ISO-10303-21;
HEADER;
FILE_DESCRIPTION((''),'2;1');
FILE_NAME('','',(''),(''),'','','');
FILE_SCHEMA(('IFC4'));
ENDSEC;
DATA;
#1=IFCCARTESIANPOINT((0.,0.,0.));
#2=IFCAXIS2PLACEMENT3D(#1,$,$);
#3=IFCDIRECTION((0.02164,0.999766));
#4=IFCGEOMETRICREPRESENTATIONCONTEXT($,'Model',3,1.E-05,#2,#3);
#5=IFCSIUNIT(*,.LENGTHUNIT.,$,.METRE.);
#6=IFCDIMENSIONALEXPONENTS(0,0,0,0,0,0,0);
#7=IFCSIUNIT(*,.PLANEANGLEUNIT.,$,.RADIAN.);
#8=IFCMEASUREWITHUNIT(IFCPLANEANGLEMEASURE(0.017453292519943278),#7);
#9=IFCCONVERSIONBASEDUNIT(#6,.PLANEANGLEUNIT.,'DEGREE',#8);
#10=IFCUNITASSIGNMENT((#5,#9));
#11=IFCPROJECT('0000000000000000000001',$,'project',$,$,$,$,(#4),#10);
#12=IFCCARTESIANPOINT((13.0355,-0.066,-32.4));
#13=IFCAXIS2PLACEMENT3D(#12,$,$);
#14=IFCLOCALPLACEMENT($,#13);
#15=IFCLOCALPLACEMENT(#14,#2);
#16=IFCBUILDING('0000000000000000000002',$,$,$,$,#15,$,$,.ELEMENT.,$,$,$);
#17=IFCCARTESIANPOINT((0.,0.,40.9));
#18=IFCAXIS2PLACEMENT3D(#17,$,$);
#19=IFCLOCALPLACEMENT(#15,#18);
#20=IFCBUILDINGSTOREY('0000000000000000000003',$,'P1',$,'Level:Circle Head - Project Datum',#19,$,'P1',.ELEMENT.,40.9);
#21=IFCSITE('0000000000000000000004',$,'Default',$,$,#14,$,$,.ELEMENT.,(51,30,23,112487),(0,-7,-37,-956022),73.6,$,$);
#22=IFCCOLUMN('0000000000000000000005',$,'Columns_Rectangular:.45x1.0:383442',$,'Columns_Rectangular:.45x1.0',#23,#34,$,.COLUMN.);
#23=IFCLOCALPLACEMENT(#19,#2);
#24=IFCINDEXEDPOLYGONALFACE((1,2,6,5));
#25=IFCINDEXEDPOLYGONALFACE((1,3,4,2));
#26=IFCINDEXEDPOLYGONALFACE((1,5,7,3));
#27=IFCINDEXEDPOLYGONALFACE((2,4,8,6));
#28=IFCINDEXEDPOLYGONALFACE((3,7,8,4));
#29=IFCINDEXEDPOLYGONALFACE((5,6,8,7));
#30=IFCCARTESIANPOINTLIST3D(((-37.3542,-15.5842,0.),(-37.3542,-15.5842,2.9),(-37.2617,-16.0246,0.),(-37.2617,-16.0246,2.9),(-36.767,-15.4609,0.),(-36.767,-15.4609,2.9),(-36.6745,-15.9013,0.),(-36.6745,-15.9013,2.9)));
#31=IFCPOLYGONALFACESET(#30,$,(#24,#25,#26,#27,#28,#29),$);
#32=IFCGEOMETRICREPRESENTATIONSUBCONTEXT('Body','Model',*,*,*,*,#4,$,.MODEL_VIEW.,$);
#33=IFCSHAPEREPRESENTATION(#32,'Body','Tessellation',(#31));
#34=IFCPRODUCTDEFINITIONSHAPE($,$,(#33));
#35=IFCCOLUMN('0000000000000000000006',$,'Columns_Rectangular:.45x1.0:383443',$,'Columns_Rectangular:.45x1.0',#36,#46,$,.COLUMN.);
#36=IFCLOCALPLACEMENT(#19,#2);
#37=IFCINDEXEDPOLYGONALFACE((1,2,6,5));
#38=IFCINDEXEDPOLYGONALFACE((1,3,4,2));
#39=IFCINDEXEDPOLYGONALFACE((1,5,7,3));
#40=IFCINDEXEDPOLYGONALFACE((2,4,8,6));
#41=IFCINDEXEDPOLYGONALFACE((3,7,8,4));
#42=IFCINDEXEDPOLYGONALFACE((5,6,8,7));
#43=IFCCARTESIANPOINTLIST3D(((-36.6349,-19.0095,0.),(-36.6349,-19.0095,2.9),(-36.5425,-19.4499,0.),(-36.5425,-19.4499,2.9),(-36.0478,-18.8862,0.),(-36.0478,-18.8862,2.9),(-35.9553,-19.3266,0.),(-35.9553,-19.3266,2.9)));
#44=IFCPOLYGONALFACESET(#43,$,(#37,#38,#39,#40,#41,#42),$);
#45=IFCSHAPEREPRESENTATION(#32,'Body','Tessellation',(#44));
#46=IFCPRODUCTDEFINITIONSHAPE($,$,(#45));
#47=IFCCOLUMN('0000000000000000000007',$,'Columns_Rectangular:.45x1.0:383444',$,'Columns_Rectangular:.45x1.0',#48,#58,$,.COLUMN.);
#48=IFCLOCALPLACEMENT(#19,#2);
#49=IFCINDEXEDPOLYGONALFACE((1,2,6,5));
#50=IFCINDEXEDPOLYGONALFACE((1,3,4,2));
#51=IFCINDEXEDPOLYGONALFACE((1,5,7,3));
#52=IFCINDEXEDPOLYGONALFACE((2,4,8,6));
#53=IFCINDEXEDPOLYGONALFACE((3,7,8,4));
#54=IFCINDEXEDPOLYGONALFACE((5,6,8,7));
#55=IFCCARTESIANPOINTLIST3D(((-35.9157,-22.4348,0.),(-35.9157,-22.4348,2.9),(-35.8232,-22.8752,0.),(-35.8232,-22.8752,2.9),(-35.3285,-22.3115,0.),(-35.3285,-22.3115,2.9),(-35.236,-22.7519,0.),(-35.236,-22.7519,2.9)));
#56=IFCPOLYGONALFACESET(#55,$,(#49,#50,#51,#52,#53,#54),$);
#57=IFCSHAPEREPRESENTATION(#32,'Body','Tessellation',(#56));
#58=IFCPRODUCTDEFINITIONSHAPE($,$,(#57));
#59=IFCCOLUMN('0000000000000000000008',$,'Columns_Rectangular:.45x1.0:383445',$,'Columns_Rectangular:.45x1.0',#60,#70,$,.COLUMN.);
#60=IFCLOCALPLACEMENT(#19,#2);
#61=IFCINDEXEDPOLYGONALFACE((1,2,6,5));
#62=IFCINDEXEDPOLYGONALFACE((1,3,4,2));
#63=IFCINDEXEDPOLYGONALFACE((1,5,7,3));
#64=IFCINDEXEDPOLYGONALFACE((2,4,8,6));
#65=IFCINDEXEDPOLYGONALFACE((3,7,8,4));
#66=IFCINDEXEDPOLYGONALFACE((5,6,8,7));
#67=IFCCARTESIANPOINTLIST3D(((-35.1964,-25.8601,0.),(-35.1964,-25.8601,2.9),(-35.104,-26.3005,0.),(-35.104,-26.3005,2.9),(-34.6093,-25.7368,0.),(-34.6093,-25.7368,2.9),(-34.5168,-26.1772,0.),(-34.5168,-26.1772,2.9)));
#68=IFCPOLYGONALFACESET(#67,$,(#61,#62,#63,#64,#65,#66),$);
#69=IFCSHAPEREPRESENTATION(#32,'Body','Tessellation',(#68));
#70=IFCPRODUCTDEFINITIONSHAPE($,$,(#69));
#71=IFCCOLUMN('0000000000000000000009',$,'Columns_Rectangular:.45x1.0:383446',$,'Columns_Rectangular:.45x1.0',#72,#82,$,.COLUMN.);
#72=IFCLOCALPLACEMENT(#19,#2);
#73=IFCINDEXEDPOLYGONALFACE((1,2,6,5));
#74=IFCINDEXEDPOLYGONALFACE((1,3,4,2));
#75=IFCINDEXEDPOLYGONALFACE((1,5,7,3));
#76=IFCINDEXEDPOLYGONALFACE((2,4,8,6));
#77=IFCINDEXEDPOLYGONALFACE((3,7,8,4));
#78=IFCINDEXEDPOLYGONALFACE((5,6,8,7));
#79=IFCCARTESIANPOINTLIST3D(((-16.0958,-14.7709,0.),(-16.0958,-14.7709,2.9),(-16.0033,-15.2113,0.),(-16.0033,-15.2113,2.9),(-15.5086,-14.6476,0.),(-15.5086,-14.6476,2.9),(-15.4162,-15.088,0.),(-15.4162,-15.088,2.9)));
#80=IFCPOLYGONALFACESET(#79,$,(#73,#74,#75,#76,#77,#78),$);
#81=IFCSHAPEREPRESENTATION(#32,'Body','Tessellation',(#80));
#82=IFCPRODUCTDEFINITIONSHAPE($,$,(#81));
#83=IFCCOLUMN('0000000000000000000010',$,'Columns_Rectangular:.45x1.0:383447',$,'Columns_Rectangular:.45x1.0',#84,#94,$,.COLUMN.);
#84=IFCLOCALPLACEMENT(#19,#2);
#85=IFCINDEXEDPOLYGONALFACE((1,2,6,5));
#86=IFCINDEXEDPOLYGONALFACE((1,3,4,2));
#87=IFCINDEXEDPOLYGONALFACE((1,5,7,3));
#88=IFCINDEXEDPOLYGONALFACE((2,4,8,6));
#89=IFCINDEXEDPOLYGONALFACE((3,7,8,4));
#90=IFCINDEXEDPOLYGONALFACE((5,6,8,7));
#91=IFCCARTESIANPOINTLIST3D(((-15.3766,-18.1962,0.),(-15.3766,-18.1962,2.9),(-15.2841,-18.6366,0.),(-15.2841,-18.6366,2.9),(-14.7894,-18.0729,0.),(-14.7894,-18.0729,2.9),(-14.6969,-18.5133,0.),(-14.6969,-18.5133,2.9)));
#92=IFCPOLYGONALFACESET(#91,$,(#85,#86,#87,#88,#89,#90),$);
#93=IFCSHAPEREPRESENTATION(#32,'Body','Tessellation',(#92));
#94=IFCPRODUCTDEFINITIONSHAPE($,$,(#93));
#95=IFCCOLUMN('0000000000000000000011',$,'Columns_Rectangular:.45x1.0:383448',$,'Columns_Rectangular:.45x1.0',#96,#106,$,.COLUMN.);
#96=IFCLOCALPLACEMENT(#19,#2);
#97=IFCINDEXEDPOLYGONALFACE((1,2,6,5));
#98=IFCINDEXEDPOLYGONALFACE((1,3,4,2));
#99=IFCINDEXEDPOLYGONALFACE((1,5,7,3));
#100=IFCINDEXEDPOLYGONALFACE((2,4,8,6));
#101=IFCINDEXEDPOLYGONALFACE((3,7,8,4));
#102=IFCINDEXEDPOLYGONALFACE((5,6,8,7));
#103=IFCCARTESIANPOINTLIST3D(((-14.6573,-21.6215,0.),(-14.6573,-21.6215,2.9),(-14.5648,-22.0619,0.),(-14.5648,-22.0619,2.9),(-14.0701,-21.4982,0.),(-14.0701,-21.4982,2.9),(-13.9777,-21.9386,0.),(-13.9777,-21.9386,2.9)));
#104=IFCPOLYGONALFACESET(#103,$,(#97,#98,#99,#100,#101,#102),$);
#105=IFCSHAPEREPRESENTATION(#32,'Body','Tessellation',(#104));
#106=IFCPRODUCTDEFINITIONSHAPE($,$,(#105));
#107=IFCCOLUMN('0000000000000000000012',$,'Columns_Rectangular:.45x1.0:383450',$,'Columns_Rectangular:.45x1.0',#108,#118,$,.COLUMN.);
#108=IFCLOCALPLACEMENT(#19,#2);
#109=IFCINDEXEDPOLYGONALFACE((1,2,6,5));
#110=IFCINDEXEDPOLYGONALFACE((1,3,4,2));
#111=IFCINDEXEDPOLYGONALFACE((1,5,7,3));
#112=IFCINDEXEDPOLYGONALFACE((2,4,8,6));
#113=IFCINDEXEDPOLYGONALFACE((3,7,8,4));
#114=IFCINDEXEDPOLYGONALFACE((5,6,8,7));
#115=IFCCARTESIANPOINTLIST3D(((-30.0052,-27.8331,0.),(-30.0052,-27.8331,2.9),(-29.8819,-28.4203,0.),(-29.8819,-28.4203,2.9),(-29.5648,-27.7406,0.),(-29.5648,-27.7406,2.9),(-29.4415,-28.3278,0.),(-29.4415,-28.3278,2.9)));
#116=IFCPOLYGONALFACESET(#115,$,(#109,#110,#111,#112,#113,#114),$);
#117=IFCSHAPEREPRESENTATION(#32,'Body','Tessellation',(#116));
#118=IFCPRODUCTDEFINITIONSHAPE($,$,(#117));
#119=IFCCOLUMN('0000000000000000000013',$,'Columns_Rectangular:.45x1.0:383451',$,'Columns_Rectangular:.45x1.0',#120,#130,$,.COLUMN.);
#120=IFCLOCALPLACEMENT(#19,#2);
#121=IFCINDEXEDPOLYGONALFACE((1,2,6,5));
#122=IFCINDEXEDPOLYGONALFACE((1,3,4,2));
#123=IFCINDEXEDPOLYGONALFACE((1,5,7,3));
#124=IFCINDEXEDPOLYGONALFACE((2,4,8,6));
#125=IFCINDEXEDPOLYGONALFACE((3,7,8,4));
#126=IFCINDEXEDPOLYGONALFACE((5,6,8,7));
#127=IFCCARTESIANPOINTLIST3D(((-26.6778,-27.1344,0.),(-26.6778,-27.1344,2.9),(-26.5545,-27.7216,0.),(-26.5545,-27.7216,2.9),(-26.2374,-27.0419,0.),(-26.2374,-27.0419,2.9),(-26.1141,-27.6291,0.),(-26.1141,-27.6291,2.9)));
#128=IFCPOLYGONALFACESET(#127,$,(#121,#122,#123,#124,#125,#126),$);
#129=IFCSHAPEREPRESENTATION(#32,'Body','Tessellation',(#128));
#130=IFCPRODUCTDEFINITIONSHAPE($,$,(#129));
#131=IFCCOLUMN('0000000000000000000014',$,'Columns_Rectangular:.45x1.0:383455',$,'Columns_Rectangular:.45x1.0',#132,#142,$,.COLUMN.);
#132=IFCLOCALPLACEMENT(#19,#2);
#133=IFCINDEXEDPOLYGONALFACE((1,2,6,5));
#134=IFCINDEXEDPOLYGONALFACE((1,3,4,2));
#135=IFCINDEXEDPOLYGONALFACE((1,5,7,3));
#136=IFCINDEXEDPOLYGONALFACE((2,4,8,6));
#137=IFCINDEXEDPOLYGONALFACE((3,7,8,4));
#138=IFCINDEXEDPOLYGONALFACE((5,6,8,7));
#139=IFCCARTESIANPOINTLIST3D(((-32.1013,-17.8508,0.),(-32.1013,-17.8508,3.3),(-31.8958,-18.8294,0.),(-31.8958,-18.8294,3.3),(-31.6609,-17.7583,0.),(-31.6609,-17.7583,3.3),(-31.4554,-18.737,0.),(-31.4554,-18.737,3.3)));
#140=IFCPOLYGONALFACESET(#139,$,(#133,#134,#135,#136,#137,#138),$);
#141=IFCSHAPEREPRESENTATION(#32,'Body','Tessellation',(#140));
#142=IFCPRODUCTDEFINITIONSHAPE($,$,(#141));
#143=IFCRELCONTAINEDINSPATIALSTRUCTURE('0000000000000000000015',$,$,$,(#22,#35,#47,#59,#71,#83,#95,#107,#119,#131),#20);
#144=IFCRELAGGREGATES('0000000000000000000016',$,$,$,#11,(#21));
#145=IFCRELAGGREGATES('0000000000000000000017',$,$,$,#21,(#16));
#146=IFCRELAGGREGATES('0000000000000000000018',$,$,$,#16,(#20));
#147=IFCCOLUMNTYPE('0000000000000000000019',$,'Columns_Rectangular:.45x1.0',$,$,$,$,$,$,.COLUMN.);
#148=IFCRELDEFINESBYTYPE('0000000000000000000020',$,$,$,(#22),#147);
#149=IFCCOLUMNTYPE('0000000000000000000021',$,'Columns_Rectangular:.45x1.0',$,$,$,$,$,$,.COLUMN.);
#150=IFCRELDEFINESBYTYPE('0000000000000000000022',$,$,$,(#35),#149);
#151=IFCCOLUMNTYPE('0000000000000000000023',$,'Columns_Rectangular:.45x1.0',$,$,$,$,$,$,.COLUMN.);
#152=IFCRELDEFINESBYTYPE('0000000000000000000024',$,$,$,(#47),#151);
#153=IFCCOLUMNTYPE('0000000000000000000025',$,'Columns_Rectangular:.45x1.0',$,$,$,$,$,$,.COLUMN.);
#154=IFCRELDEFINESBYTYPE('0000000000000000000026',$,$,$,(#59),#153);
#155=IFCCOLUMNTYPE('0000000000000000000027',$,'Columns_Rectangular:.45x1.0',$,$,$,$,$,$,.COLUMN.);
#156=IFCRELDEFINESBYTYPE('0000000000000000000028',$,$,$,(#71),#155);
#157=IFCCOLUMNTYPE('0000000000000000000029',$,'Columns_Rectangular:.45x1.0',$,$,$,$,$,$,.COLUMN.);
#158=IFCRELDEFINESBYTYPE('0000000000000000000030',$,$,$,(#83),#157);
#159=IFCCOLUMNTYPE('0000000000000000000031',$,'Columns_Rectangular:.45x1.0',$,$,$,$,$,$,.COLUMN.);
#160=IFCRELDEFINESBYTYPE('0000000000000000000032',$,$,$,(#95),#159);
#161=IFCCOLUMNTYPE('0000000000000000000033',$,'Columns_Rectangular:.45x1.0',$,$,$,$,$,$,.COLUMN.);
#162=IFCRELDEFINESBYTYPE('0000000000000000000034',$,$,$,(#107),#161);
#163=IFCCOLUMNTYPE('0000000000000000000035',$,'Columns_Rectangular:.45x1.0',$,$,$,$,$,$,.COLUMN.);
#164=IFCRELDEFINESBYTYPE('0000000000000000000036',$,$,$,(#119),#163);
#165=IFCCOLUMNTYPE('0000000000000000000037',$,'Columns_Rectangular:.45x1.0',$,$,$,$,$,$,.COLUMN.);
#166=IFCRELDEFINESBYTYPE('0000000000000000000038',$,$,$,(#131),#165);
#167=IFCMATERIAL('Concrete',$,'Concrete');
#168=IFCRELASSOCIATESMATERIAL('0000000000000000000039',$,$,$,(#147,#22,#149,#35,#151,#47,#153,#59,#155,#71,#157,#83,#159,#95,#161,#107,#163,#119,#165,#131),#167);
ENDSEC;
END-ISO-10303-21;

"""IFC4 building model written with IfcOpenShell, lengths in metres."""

from ifc_helpers import new_model, entity, si_unit, converted_unit, direction, frame, origin, place, context, subcontext, project, spatial, indexed_curve, outline, extrude, source, transform, mapped, material, type_object, type_shapes, element, save


model = new_model("IFC4")

# Units and contexts
model_context = context("Model", 3, precision=1e-05, world=origin(), true_north=direction((0.02164, 0.999766)))
body_context = subcontext(model_context, "Body", "Model", "MODEL_VIEW")
ifc_project = project(units=[si_unit("LENGTHUNIT", "METRE"), converted_unit("PLANEANGLEUNIT", "DEGREE", entity("IfcPlaneAngleMeasure", 0.017453292519943278), si_unit("PLANEANGLEUNIT", "RADIAN"), dimensions=[0, 0, 0, 0, 0, 0, 0])], contexts=[model_context])

# Site, building, storey
site_placement = place(None, frame((13.0355, -0.066, -32.4)))
site = spatial("IfcSite", under=ifc_project, at=site_placement, Name="Default", CompositionType="ELEMENT", RefLatitude=(51, 30, 23, 112487), RefLongitude=(0, -7, -37, -956022), RefElevation=73.6)
building_placement = place(site_placement, origin())
building = spatial("IfcBuilding", under=site, at=building_placement, CompositionType="ELEMENT")
storey_placement = place(building_placement, frame((0.0, 0.0, 40.9)))
storey = spatial("IfcBuildingStorey", under=building, at=storey_placement, Name="P1", ObjectType="Level:Circle Head - Project Datum", LongName="P1", CompositionType="ELEMENT", Elevation=40.9)

# Columns
ifc_material = material(Name="Concrete", Category="Concrete")
column_type_1 = type_object("IfcColumnType", Name="Columns_Rectangular:.45x1.0", PredefinedType="COLUMN", material=ifc_material)
shared_shape_1 = source(origin(), body_context, "Body", "SweptSolid", [
    extrude(outline(indexed_curve([(-0.3, -0.225), (0.3, -0.225), (0.3, 0.225), (-0.3, 0.225), (-0.3, -0.225)], self_intersect=False)), frame((-37.0144, -15.7427, 40.9), z_axis=(0.0, 0.0, 1.0), x_axis=(0.978657, 0.2055, 0.0)), (0.0, 0.0, 1.0), 2.9),
])
type_shapes(column_type_1, [shared_shape_1])
column_1_placement = place(storey_placement, frame((0.0, 0.0, -40.9)))
element("IfcColumn", 1, at=column_1_placement, inside=storey, type_object=column_type_1, material=ifc_material, Name="Columns_Rectangular:.45x1.0:383442", ObjectType="Columns_Rectangular:.45x1.0", PredefinedType="COLUMN", context=body_context, shape_type="MappedRepresentation", body=[
    mapped(shared_shape_1, transform((0.0, 0.0, 0.0), scale=1.0)),
])
column_type_2 = type_object("IfcColumnType", Name="Columns_Rectangular:.45x1.0", PredefinedType="COLUMN", material=ifc_material)
shared_shape_2 = source(origin(), body_context, "Body", "SweptSolid", [
    extrude(outline(indexed_curve([(-0.3, -0.225), (0.3, -0.225), (0.3, 0.225), (-0.3, 0.225), (-0.3, -0.225)], self_intersect=False)), frame((-36.2951, -19.168, 40.9), z_axis=(0.0, 0.0, 1.0), x_axis=(0.978657, 0.2055, 0.0)), (0.0, 0.0, 1.0), 2.9),
])
type_shapes(column_type_2, [shared_shape_2])
column_2_placement = place(storey_placement, frame((0.0, 0.0, -40.9)))
element("IfcColumn", 2, at=column_2_placement, inside=storey, type_object=column_type_2, material=ifc_material, Name="Columns_Rectangular:.45x1.0:383443", ObjectType="Columns_Rectangular:.45x1.0", PredefinedType="COLUMN", context=body_context, shape_type="MappedRepresentation", body=[
    mapped(shared_shape_2, transform((0.0, 0.0, 0.0), scale=1.0)),
])
column_type_3 = type_object("IfcColumnType", Name="Columns_Rectangular:.45x1.0", PredefinedType="COLUMN", material=ifc_material)
shared_shape_3 = source(origin(), body_context, "Body", "SweptSolid", [
    extrude(outline(indexed_curve([(-0.3, -0.225), (0.3, -0.225), (0.3, 0.225), (-0.3, 0.225), (-0.3, -0.225)], self_intersect=False)), frame((-35.5759, -22.5933, 40.9), z_axis=(0.0, 0.0, 1.0), x_axis=(0.978657, 0.2055, 0.0)), (0.0, 0.0, 1.0), 2.9),
])
type_shapes(column_type_3, [shared_shape_3])
column_3_placement = place(storey_placement, frame((0.0, 0.0, -40.9)))
element("IfcColumn", 3, at=column_3_placement, inside=storey, type_object=column_type_3, material=ifc_material, Name="Columns_Rectangular:.45x1.0:383444", ObjectType="Columns_Rectangular:.45x1.0", PredefinedType="COLUMN", context=body_context, shape_type="MappedRepresentation", body=[
    mapped(shared_shape_3, transform((0.0, 0.0, 0.0), scale=1.0)),
])
column_type_4 = type_object("IfcColumnType", Name="Columns_Rectangular:.45x1.0", PredefinedType="COLUMN", material=ifc_material)
shared_shape_4 = source(origin(), body_context, "Body", "SweptSolid", [
    extrude(outline(indexed_curve([(-0.3, -0.225), (0.3, -0.225), (0.3, 0.225), (-0.3, 0.225), (-0.3, -0.225)], self_intersect=False)), frame((-34.8566, -26.0186, 40.9), z_axis=(0.0, 0.0, 1.0), x_axis=(0.978657, 0.2055, 0.0)), (0.0, 0.0, 1.0), 2.9),
])
type_shapes(column_type_4, [shared_shape_4])
column_4_placement = place(storey_placement, frame((0.0, 0.0, -40.9)))
element("IfcColumn", 4, at=column_4_placement, inside=storey, type_object=column_type_4, material=ifc_material, Name="Columns_Rectangular:.45x1.0:383445", ObjectType="Columns_Rectangular:.45x1.0", PredefinedType="COLUMN", context=body_context, shape_type="MappedRepresentation", body=[
    mapped(shared_shape_4, transform((0.0, 0.0, 0.0), scale=1.0)),
])
column_type_5 = type_object("IfcColumnType", Name="Columns_Rectangular:.45x1.0", PredefinedType="COLUMN", material=ifc_material)
shared_shape_5 = source(origin(), body_context, "Body", "SweptSolid", [
    extrude(outline(indexed_curve([(-0.3, -0.225), (0.3, -0.225), (0.3, 0.225), (-0.3, 0.225), (-0.3, -0.225)], self_intersect=False)), frame((-15.756, -14.9295, 40.9), z_axis=(0.0, 0.0, 1.0), x_axis=(0.978657, 0.2055, 0.0)), (0.0, 0.0, 1.0), 2.9),
])
type_shapes(column_type_5, [shared_shape_5])
column_5_placement = place(storey_placement, frame((0.0, 0.0, -40.9)))
element("IfcColumn", 5, at=column_5_placement, inside=storey, type_object=column_type_5, material=ifc_material, Name="Columns_Rectangular:.45x1.0:383446", ObjectType="Columns_Rectangular:.45x1.0", PredefinedType="COLUMN", context=body_context, shape_type="MappedRepresentation", body=[
    mapped(shared_shape_5, transform((0.0, 0.0, 0.0), scale=1.0)),
])
column_type_6 = type_object("IfcColumnType", Name="Columns_Rectangular:.45x1.0", PredefinedType="COLUMN", material=ifc_material)
shared_shape_6 = source(origin(), body_context, "Body", "SweptSolid", [
    extrude(outline(indexed_curve([(-0.3, -0.225), (0.3, -0.225), (0.3, 0.225), (-0.3, 0.225), (-0.3, -0.225)], self_intersect=False)), frame((-15.0367, -18.3548, 40.9), z_axis=(0.0, 0.0, 1.0), x_axis=(0.978657, 0.2055, 0.0)), (0.0, 0.0, 1.0), 2.9),
])
type_shapes(column_type_6, [shared_shape_6])
column_6_placement = place(storey_placement, frame((0.0, 0.0, -40.9)))
element("IfcColumn", 6, at=column_6_placement, inside=storey, type_object=column_type_6, material=ifc_material, Name="Columns_Rectangular:.45x1.0:383447", ObjectType="Columns_Rectangular:.45x1.0", PredefinedType="COLUMN", context=body_context, shape_type="MappedRepresentation", body=[
    mapped(shared_shape_6, transform((0.0, 0.0, 0.0), scale=1.0)),
])
column_type_7 = type_object("IfcColumnType", Name="Columns_Rectangular:.45x1.0", PredefinedType="COLUMN", material=ifc_material)
shared_shape_7 = source(origin(), body_context, "Body", "SweptSolid", [
    extrude(outline(indexed_curve([(-0.3, -0.225), (0.3, -0.225), (0.3, 0.225), (-0.3, 0.225), (-0.3, -0.225)], self_intersect=False)), frame((-14.3175, -21.7801, 40.9), z_axis=(0.0, 0.0, 1.0), x_axis=(0.978657, 0.2055, 0.0)), (0.0, 0.0, 1.0), 2.9),
])
type_shapes(column_type_7, [shared_shape_7])
column_7_placement = place(storey_placement, frame((0.0, 0.0, -40.9)))
element("IfcColumn", 7, at=column_7_placement, inside=storey, type_object=column_type_7, material=ifc_material, Name="Columns_Rectangular:.45x1.0:383448", ObjectType="Columns_Rectangular:.45x1.0", PredefinedType="COLUMN", context=body_context, shape_type="MappedRepresentation", body=[
    mapped(shared_shape_7, transform((0.0, 0.0, 0.0), scale=1.0)),
])
column_type_8 = type_object("IfcColumnType", Name="Columns_Rectangular:.45x1.0", PredefinedType="COLUMN", material=ifc_material)
shared_shape_8 = source(origin(), body_context, "Body", "SweptSolid", [
    extrude(outline(indexed_curve([(-0.3, -0.225), (0.3, -0.225), (0.3, 0.225), (-0.3, 0.225), (-0.3, -0.225)], self_intersect=False)), frame((-29.7234, -28.0804, 40.9), z_axis=(0.0, 0.0, 1.0), x_axis=(0.2055, -0.978657, 0.0)), (0.0, 0.0, 1.0), 2.9),
])
type_shapes(column_type_8, [shared_shape_8])
column_8_placement = place(storey_placement, frame((0.0, 0.0, -40.9)))
element("IfcColumn", 8, at=column_8_placement, inside=storey, type_object=column_type_8, material=ifc_material, Name="Columns_Rectangular:.45x1.0:383450", ObjectType="Columns_Rectangular:.45x1.0", PredefinedType="COLUMN", context=body_context, shape_type="MappedRepresentation", body=[
    mapped(shared_shape_8, transform((0.0, 0.0, 0.0), scale=1.0)),
])
column_type_9 = type_object("IfcColumnType", Name="Columns_Rectangular:.45x1.0", PredefinedType="COLUMN", material=ifc_material)
shared_shape_9 = source(origin(), body_context, "Body", "SweptSolid", [
    extrude(outline(indexed_curve([(-0.3, -0.225), (0.3, -0.225), (0.3, 0.225), (-0.3, 0.225), (-0.3, -0.225)], self_intersect=False)), frame((-26.3959, -27.3817, 40.9), z_axis=(0.0, 0.0, 1.0), x_axis=(0.2055, -0.978657, 0.0)), (0.0, 0.0, 1.0), 2.9),
])
type_shapes(column_type_9, [shared_shape_9])
column_9_placement = place(storey_placement, frame((0.0, 0.0, -40.9)))
element("IfcColumn", 9, at=column_9_placement, inside=storey, type_object=column_type_9, material=ifc_material, Name="Columns_Rectangular:.45x1.0:383451", ObjectType="Columns_Rectangular:.45x1.0", PredefinedType="COLUMN", context=body_context, shape_type="MappedRepresentation", body=[
    mapped(shared_shape_9, transform((0.0, 0.0, 0.0), scale=1.0)),
])
column_type_10 = type_object("IfcColumnType", Name="Columns_Rectangular:.45x1.0", PredefinedType="COLUMN", material=ifc_material)
shared_shape_10 = source(origin(), body_context, "Body", "SweptSolid", [
    extrude(outline(indexed_curve([(-0.5, -0.225), (0.5, -0.225), (0.5, 0.225), (-0.5, 0.225), (-0.5, -0.225)], self_intersect=False)), frame((-31.7784, -18.2939, 40.9), z_axis=(0.0, 0.0, 1.0), x_axis=(-0.2055, 0.978657, 0.0)), (0.0, 0.0, 1.0), 3.3),
])
type_shapes(column_type_10, [shared_shape_10])
column_10_placement = place(storey_placement, frame((0.0, 0.0, -40.9)))
element("IfcColumn", 10, at=column_10_placement, inside=storey, type_object=column_type_10, material=ifc_material, Name="Columns_Rectangular:.45x1.0:383455", ObjectType="Columns_Rectangular:.45x1.0", PredefinedType="COLUMN", context=body_context, shape_type="MappedRepresentation", body=[
    mapped(shared_shape_10, transform((0.0, 0.0, 0.0), scale=1.0)),
])

save(model, "model.ifc")
